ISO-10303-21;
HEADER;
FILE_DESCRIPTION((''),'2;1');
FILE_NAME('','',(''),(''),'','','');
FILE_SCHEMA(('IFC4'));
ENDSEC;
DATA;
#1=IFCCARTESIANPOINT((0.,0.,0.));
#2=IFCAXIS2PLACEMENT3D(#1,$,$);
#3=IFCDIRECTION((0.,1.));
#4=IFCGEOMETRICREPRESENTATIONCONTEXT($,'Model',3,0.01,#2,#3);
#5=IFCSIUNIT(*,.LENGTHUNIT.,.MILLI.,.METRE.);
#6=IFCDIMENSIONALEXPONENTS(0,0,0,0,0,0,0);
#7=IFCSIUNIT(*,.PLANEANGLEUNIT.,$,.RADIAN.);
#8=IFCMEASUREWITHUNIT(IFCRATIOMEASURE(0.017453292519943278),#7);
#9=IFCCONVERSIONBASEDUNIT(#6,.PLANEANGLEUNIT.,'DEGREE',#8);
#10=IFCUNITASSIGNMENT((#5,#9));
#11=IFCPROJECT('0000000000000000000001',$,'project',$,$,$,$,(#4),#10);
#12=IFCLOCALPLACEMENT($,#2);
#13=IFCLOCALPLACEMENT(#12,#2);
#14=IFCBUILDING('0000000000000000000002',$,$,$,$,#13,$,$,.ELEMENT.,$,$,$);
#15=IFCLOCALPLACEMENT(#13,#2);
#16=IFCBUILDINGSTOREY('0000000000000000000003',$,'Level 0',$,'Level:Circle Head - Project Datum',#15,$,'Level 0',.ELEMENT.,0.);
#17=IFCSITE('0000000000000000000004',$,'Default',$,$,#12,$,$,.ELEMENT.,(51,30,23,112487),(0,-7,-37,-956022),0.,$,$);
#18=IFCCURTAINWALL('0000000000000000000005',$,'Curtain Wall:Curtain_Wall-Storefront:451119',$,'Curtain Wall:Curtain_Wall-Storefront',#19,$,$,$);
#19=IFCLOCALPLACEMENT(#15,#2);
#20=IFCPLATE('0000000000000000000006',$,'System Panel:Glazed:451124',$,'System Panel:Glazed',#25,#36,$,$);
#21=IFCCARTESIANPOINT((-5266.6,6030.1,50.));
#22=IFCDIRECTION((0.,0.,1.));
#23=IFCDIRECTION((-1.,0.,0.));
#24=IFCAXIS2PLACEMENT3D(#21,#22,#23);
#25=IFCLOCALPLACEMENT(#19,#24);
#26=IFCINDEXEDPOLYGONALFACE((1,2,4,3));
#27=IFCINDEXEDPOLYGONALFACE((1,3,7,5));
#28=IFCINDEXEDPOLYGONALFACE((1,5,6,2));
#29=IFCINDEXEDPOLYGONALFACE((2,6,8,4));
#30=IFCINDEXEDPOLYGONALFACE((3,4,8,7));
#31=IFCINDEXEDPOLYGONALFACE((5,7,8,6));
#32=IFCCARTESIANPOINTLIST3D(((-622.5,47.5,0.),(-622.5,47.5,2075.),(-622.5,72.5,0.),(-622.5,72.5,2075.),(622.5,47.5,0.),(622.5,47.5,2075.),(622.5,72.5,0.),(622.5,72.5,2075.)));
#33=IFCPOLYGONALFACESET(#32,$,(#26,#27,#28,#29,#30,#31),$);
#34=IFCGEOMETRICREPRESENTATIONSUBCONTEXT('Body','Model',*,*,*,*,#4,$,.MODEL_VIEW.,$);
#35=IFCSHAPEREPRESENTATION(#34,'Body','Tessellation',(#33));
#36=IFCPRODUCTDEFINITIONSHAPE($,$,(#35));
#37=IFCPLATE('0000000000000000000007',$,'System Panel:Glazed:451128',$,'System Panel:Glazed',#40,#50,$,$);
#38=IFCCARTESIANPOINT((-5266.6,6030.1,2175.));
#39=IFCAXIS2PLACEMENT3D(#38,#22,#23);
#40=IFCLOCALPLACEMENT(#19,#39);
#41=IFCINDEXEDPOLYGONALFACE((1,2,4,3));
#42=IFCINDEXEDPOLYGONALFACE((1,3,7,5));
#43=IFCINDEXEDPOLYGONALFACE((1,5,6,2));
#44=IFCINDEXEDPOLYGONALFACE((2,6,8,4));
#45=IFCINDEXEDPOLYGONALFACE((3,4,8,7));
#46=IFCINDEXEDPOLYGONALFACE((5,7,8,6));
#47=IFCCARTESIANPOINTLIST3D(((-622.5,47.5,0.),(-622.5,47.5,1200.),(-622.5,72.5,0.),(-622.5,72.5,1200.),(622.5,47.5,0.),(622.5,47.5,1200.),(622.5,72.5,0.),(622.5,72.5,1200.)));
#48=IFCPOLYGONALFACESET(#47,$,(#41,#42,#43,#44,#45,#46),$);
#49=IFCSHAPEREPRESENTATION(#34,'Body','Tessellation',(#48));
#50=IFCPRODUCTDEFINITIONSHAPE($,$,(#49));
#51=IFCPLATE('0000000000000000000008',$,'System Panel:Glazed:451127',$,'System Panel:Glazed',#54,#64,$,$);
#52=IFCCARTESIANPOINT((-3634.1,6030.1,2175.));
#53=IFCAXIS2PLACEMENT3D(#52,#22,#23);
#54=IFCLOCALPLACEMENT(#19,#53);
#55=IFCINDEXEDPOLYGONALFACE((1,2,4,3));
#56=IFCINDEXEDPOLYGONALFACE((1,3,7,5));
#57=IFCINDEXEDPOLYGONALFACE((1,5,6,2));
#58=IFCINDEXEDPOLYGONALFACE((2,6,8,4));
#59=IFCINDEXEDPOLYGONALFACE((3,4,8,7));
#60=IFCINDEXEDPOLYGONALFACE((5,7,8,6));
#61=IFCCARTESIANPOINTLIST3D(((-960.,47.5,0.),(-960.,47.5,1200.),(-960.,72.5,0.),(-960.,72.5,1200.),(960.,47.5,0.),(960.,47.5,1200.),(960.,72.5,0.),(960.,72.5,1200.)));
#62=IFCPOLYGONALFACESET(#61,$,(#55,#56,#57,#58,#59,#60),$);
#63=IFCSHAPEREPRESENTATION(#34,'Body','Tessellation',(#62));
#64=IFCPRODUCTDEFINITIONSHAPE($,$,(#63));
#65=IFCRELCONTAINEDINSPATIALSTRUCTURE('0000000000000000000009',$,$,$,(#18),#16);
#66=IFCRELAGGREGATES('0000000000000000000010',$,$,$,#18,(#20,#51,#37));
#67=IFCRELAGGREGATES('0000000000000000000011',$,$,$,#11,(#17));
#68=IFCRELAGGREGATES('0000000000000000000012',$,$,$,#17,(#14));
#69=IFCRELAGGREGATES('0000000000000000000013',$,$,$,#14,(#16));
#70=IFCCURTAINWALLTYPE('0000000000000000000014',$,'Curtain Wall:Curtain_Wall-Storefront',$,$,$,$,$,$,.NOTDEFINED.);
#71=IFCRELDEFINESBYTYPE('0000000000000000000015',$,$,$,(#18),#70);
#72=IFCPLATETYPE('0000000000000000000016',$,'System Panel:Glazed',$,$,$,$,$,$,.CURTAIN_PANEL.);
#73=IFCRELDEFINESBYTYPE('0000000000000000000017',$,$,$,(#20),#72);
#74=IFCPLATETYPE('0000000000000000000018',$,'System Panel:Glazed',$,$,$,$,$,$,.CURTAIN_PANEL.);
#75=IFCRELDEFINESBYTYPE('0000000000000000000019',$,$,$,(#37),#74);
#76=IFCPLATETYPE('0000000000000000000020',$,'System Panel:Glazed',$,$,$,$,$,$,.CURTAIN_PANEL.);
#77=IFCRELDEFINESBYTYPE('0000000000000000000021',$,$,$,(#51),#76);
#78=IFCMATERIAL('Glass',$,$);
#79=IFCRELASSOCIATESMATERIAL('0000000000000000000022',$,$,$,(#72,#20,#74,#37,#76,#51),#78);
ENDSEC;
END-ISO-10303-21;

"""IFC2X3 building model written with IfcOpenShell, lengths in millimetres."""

from ifc_helpers import new_model, entity, si_unit, converted_unit, direction, frame, origin, origin_2d_with_axis, place, context, subcontext, project, spatial, rectangle, extrude, source, transform, mapped, material, type_object, type_shapes, element, aggregate, save


model = new_model("IFC2X3")

# Units and contexts
model_context = context("Model", 3, precision=0.01, world=origin(), true_north=direction((0.0, 1.0)))
body_context = subcontext(model_context, "Body", "Model", "MODEL_VIEW")
ifc_project = project(units=[si_unit("LENGTHUNIT", "METRE", prefix="MILLI"), converted_unit("PLANEANGLEUNIT", "DEGREE", entity("IfcRatioMeasure", 0.017453292519943278), si_unit("PLANEANGLEUNIT", "RADIAN"), dimensions=[0, 0, 0, 0, 0, 0, 0])], contexts=[model_context])

# Site, building, storey
site_placement = place(None, origin())
site = spatial("IfcSite", under=ifc_project, at=site_placement, Name="Default", CompositionType="ELEMENT", RefLatitude=(51, 30, 23, 112487), RefLongitude=(0, -7, -37, -956022), RefElevation=0.0)
building_placement = place(site_placement, origin())
building = spatial("IfcBuilding", under=site, at=building_placement, CompositionType="ELEMENT")
storey_placement = place(building_placement, origin())
storey = spatial("IfcBuildingStorey", under=building, at=storey_placement, Name="Level 0", ObjectType="Level:Circle Head - Project Datum", LongName="Level 0", CompositionType="ELEMENT", Elevation=0.0)

# Curtain wall
curtain_wall_type = type_object("IfcCurtainWallType", Name="Curtain Wall:Curtain_Wall-Storefront", PredefinedType="NOTDEFINED")
curtain_wall_1_placement = place(storey_placement, origin())
curtain_wall_1 = element("IfcCurtainWall", 1, at=curtain_wall_1_placement, inside=storey, type_object=curtain_wall_type, Name="Curtain Wall:Curtain_Wall-Storefront:451119", ObjectType="Curtain Wall:Curtain_Wall-Storefront")

# Plates
ifc_material_1 = material(Name="Glass")
plate_type_1 = type_object("IfcPlateType", Name="System Panel:Glazed", PredefinedType="CURTAIN_PANEL", material=ifc_material_1)
shared_shape_1 = source(origin(), body_context, "Body", "SweptSolid", [
    extrude(rectangle(XDim=25.0, YDim=1245.0, at=origin_2d_with_axis()), frame((0.0, 60.0, 0.0), z_axis=(0.0, 0.0, 1.0), x_axis=(0.0, 1.0, 0.0)), (0.0, 0.0, 1.0), 2075.0),
])
type_shapes(plate_type_1, [shared_shape_1])
plate_1_placement = place(curtain_wall_1_placement, frame((-5266.6, 6030.1, 50.0), z_axis=(0.0, 0.0, 1.0), x_axis=(-1.0, 0.0, 0.0)))
plate_1 = element("IfcPlate", 2, at=plate_1_placement, type_object=plate_type_1, material=ifc_material_1, Name="System Panel:Glazed:451124", ObjectType="System Panel:Glazed", context=body_context, shape_type="MappedRepresentation", body=[
    mapped(shared_shape_1, transform((0.0, 0.0, 0.0), scale=1.0)),
])
plate_type_2 = type_object("IfcPlateType", Name="System Panel:Glazed", PredefinedType="CURTAIN_PANEL", material=ifc_material_1)
shared_shape_2 = source(origin(), body_context, "Body", "SweptSolid", [
    extrude(rectangle(XDim=25.0, YDim=1245.0, at=origin_2d_with_axis()), frame((0.0, 60.0, 0.0), z_axis=(0.0, 0.0, 1.0), x_axis=(0.0, 1.0, 0.0)), (0.0, 0.0, 1.0), 1200.0),
])
type_shapes(plate_type_2, [shared_shape_2])
plate_2_placement = place(curtain_wall_1_placement, frame((-5266.6, 6030.1, 2175.0), z_axis=(0.0, 0.0, 1.0), x_axis=(-1.0, 0.0, 0.0)))
plate_2 = element("IfcPlate", 3, at=plate_2_placement, type_object=plate_type_2, material=ifc_material_1, Name="System Panel:Glazed:451128", ObjectType="System Panel:Glazed", context=body_context, shape_type="MappedRepresentation", body=[
    mapped(shared_shape_2, transform((0.0, 0.0, 0.0), scale=1.0)),
])
plate_type_3 = type_object("IfcPlateType", Name="System Panel:Glazed", PredefinedType="CURTAIN_PANEL", material=ifc_material_1)
shared_shape_3 = source(origin(), body_context, "Body", "SweptSolid", [
    extrude(rectangle(XDim=25.0, YDim=1920.0, at=origin_2d_with_axis()), frame((0.0, 60.0, 0.0), z_axis=(0.0, 0.0, 1.0), x_axis=(0.0, 1.0, 0.0)), (0.0, 0.0, 1.0), 1200.0),
])
type_shapes(plate_type_3, [shared_shape_3])
plate_3_placement = place(curtain_wall_1_placement, frame((-3634.1, 6030.1, 2175.0), z_axis=(0.0, 0.0, 1.0), x_axis=(-1.0, 0.0, 0.0)))
plate_3 = element("IfcPlate", 4, at=plate_3_placement, type_object=plate_type_3, material=ifc_material_1, Name="System Panel:Glazed:451127", ObjectType="System Panel:Glazed", context=body_context, shape_type="MappedRepresentation", body=[
    mapped(shared_shape_3, transform((0.0, 0.0, 0.0), scale=1.0)),
])
aggregate(curtain_wall_1, [plate_1, plate_3, plate_2])

save(model, "model.ifc")
